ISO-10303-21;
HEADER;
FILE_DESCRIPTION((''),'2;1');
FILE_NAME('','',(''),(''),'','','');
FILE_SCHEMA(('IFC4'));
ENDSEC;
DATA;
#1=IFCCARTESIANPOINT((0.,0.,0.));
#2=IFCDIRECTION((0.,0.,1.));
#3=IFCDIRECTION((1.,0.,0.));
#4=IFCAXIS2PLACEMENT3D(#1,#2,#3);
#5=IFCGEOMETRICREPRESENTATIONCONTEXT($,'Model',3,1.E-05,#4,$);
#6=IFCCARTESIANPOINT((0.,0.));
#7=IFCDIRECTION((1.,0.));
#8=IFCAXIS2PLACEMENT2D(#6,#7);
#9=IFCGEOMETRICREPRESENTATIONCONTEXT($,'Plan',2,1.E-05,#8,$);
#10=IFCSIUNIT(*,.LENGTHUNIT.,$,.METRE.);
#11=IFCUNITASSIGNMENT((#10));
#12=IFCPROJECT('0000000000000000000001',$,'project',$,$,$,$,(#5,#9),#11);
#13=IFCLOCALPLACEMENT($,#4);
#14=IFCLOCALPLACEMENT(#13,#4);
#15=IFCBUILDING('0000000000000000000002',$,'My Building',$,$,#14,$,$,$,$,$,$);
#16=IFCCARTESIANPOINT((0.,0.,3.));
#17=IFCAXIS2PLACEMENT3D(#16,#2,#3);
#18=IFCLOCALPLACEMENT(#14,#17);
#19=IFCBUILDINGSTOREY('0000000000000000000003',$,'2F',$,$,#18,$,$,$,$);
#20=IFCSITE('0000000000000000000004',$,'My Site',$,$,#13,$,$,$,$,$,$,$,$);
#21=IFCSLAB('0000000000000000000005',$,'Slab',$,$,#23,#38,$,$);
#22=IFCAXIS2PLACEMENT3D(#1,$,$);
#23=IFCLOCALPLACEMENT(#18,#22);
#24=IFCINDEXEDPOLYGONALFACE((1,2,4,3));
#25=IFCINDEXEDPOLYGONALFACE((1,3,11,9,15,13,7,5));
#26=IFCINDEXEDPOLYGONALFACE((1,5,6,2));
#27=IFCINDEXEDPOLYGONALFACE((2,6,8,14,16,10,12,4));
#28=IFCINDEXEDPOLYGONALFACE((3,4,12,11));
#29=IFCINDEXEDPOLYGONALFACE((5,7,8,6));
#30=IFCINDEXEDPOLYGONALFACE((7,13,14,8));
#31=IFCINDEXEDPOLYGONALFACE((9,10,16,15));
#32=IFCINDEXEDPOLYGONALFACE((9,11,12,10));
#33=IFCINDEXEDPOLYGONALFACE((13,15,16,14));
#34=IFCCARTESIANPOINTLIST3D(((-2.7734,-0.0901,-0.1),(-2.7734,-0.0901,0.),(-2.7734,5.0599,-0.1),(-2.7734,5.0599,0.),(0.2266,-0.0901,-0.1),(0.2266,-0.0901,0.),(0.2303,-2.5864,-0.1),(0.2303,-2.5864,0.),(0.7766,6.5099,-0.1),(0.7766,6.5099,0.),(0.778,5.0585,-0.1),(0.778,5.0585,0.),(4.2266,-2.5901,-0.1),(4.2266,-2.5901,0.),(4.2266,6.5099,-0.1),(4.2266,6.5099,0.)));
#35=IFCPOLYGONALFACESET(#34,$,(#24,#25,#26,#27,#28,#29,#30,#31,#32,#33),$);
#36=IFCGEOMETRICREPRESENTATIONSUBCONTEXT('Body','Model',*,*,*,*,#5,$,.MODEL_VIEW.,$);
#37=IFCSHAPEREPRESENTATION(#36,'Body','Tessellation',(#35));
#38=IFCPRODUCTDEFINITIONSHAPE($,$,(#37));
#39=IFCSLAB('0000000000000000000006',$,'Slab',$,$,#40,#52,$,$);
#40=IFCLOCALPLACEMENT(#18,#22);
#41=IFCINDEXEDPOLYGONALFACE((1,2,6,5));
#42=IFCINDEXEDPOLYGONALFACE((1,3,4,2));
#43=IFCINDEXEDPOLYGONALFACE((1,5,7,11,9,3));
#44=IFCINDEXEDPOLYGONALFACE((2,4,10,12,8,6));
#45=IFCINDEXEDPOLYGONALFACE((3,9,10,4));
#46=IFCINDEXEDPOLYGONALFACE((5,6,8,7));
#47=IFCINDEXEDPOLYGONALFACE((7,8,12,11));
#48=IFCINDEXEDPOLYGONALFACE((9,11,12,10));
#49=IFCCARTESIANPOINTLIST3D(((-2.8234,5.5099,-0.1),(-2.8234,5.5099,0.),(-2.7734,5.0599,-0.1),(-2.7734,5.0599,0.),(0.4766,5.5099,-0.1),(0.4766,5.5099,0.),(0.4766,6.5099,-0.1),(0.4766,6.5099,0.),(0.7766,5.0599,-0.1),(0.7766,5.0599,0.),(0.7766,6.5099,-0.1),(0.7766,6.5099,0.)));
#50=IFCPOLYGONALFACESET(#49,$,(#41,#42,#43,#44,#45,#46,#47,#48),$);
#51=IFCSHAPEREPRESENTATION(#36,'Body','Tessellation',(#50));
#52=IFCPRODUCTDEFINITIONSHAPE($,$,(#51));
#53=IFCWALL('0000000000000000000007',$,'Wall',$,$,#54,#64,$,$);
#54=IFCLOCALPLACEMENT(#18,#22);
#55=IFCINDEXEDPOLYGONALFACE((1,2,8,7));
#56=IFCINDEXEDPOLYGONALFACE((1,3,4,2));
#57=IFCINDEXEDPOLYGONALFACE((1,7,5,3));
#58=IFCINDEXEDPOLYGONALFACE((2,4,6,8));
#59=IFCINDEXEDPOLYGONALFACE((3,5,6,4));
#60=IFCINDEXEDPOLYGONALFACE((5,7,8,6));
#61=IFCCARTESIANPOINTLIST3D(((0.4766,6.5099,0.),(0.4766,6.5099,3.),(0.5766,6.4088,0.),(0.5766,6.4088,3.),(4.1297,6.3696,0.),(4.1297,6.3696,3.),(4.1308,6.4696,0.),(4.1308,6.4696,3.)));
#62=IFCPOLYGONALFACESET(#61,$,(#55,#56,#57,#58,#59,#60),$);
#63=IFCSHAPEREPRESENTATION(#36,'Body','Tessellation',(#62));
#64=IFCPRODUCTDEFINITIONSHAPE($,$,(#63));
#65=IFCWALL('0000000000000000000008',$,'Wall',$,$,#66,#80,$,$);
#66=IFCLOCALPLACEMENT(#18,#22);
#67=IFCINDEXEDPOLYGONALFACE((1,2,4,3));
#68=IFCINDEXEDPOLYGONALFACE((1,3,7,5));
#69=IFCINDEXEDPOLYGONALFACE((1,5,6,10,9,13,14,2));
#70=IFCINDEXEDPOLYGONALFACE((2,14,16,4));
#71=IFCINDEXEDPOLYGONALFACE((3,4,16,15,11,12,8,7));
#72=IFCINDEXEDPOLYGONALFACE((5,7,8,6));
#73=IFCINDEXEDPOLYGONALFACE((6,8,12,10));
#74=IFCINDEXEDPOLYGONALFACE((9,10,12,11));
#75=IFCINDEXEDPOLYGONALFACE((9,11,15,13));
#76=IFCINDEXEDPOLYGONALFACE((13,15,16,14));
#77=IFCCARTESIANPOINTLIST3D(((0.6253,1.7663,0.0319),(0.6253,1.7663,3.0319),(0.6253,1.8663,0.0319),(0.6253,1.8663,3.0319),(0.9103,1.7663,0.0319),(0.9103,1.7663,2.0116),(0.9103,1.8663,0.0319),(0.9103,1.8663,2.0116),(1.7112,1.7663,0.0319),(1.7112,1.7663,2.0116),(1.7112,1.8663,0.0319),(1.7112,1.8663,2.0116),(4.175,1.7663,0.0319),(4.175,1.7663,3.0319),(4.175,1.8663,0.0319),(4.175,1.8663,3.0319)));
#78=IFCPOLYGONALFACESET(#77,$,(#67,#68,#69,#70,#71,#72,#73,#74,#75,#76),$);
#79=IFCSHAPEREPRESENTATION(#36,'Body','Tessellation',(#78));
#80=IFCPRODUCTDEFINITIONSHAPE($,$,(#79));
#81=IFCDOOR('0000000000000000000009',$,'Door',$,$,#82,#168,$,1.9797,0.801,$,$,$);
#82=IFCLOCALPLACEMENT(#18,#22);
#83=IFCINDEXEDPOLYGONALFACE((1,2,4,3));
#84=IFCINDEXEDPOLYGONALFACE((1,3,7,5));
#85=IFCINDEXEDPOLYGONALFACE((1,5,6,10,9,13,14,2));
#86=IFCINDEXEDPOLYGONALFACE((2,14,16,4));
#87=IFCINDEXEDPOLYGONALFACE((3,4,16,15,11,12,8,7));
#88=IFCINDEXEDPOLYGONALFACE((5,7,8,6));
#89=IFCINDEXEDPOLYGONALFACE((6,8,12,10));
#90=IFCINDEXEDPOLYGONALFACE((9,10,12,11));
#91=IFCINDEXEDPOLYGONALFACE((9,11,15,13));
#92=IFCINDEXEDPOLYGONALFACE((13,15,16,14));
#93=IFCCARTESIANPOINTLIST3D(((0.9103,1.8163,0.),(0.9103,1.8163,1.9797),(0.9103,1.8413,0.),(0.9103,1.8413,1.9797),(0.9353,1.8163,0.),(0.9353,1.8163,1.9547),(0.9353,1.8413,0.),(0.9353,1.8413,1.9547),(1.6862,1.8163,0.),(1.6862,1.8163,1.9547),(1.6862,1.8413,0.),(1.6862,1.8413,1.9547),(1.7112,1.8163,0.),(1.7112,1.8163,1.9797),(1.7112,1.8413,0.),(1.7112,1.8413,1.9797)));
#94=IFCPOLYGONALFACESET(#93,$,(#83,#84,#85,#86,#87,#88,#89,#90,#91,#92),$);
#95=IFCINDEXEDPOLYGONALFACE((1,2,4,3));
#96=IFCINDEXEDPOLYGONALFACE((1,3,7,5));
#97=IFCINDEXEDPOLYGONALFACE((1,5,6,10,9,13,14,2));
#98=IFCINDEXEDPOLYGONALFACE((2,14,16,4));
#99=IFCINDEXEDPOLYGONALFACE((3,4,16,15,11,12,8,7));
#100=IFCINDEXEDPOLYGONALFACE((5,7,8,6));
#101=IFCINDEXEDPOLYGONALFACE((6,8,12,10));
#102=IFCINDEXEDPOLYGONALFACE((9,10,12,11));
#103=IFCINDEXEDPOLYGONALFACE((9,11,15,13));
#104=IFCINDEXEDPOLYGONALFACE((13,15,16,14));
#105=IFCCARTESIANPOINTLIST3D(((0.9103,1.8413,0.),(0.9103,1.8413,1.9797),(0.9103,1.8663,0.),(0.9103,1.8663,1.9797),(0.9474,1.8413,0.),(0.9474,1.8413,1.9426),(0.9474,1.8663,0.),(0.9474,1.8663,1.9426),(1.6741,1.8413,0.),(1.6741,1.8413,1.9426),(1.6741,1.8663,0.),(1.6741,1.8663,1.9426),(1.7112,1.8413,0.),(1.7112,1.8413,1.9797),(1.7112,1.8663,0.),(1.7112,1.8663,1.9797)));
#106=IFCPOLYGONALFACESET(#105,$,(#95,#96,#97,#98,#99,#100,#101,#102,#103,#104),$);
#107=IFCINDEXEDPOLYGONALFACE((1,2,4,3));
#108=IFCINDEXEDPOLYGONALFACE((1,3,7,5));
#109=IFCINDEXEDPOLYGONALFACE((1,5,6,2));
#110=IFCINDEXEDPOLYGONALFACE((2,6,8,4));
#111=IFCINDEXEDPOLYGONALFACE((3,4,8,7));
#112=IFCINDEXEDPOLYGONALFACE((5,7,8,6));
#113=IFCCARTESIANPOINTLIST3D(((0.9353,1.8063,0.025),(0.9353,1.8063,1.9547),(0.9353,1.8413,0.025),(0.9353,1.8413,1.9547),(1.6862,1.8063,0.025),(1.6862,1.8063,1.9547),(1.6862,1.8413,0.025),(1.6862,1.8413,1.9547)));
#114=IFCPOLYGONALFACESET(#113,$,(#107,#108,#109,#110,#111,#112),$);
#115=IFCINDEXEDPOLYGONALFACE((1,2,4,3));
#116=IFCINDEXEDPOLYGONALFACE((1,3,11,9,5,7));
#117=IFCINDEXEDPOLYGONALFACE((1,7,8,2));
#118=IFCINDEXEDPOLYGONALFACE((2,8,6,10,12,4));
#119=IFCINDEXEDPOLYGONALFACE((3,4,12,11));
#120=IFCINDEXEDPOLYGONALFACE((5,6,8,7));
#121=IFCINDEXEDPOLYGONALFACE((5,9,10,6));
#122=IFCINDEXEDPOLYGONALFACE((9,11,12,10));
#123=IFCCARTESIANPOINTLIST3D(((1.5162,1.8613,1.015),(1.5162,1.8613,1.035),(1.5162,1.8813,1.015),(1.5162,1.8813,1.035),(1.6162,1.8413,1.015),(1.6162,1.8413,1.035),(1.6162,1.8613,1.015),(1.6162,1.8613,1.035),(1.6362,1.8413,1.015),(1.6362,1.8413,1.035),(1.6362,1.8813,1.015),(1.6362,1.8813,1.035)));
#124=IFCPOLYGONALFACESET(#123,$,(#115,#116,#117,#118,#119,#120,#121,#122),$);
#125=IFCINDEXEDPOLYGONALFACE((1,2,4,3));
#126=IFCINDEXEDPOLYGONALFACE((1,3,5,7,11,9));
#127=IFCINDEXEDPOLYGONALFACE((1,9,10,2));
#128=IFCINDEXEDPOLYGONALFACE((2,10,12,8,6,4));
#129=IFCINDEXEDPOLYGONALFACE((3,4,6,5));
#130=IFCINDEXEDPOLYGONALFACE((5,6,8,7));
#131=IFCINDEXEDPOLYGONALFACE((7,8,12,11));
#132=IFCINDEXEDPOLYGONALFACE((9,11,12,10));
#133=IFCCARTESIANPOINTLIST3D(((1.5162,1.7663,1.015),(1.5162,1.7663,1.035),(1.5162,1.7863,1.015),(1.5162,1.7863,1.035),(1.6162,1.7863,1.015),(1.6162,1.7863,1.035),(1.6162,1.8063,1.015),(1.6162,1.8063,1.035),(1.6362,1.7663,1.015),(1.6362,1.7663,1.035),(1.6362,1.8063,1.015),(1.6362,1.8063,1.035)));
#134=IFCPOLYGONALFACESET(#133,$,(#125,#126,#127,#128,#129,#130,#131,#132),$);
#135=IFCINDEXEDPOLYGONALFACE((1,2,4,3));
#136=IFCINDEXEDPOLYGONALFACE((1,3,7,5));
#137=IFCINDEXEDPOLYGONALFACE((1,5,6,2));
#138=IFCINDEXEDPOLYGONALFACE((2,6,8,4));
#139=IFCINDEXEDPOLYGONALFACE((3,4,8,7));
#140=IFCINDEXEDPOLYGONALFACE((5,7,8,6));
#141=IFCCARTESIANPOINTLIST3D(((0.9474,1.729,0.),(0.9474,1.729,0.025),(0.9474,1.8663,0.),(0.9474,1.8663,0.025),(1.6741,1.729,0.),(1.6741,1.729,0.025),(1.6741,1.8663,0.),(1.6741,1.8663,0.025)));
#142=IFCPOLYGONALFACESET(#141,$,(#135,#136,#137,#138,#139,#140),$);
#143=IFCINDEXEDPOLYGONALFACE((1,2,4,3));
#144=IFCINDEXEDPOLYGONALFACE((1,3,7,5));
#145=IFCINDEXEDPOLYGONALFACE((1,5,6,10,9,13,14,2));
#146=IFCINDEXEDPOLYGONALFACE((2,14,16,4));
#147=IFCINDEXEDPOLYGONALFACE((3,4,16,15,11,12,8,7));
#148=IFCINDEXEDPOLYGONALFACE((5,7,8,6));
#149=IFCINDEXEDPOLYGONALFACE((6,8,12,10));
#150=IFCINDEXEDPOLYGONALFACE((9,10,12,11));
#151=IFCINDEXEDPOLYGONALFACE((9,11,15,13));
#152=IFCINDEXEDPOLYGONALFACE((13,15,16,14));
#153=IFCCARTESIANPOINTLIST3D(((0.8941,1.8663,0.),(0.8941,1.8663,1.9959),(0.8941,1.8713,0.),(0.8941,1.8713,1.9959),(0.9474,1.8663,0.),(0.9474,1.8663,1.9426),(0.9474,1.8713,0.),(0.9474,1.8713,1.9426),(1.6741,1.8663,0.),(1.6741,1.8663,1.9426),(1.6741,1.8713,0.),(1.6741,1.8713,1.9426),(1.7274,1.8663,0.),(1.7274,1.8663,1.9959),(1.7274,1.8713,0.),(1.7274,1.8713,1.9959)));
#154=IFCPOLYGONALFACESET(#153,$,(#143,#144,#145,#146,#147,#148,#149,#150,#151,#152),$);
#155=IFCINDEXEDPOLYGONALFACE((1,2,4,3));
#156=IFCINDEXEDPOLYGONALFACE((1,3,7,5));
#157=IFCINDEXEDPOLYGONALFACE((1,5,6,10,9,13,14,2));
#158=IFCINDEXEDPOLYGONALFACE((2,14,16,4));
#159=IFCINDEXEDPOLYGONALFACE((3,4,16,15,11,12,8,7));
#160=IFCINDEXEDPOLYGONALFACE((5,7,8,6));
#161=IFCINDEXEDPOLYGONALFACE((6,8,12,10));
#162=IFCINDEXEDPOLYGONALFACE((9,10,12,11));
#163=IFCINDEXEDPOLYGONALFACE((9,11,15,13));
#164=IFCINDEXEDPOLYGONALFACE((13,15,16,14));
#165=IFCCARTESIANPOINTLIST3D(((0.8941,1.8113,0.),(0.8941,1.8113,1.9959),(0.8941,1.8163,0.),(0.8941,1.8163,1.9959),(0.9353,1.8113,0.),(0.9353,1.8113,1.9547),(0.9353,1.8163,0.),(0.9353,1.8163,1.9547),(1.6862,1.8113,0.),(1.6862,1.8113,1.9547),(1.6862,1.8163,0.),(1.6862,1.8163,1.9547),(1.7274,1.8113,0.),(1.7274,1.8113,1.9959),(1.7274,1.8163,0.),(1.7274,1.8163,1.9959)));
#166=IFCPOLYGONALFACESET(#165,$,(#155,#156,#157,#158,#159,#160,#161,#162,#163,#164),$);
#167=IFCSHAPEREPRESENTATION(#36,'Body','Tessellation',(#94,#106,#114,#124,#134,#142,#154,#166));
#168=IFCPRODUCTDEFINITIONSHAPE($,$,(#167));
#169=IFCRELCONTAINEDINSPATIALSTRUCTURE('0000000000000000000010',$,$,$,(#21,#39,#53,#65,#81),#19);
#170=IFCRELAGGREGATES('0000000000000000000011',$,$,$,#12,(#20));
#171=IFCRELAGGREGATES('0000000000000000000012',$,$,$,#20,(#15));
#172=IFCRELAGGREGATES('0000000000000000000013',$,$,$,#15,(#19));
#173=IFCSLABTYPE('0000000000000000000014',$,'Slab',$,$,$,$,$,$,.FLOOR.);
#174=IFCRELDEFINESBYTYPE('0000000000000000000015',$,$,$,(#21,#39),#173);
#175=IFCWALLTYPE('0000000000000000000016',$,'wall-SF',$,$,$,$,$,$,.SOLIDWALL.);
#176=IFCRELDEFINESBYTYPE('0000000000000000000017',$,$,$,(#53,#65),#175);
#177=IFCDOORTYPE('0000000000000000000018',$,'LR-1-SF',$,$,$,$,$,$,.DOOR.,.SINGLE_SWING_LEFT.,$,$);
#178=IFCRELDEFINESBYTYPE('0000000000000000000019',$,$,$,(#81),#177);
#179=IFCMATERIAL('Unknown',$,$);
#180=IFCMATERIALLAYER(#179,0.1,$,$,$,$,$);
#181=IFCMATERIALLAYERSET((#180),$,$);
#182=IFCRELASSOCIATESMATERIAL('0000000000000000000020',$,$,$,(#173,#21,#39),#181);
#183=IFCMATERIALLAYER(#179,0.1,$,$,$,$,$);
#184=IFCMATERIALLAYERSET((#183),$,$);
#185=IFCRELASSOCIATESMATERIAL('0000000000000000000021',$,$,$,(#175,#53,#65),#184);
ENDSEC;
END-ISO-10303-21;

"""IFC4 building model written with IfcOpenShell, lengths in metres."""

from ifc_helpers import new_model, entity, si_unit, frame, origin_with_axes, origin_2d_with_axis, place, context, subcontext, project, spatial, line, indexed_curve, outline, extrude, shape, source, transform, mapped, material, layer, layer_set, layer_usage, type_object, type_shapes, element, fill, save


model = new_model("IFC4")

# Units and contexts
model_context = context("Model", 3, precision=1e-05, world=origin_with_axes())
plan_context = context("Plan", 2, precision=1e-05, world=origin_2d_with_axis())
body_context_1 = subcontext(model_context, "Body", "Model", "MODEL_VIEW")
body_context_2 = subcontext(plan_context, "Body", "Plan", "PLAN_VIEW")
ifc_project = project(units=[si_unit("LENGTHUNIT", "METRE")], contexts=[model_context, plan_context])

# Site, building, storey
site_placement = place(None, origin_with_axes())
site = spatial("IfcSite", under=ifc_project, at=site_placement, Name="My Site")
building_placement = place(site_placement, origin_with_axes())
building = spatial("IfcBuilding", under=site, at=building_placement, Name="My Building")
storey_placement = place(building_placement, frame((0.0, 0.0, 3.0), z_axis=(0.0, 0.0, 1.0), x_axis=(1.0, 0.0, 0.0)))
storey = spatial("IfcBuildingStorey", under=building, at=storey_placement, Name="2F")

# Slabs
ifc_material = material(Name="Unknown")
ifc_layer_1 = layer(ifc_material, 0.1)
ifc_layer_set_1 = layer_set([ifc_layer_1])
ifc_layer_usage_1 = layer_usage(ifc_layer_set_1, "AXIS3", "POSITIVE", -0.1)
slab_type = type_object("IfcSlabType", Name="Slab", PredefinedType="FLOOR", material=ifc_layer_set_1)
slab_1_placement = place(storey_placement, frame((0.7766, 6.5099, 0.0), z_axis=(0.0, 0.0, 1.0), x_axis=(1.0, 0.0, 0.0)))
element("IfcSlab", 1, at=slab_1_placement, inside=storey, type_object=slab_type, material=ifc_layer_usage_1, Name="Slab", context=body_context_1, shape_type="SweptSolid", body=[
    extrude(outline(indexed_curve([(0.0, 0.0), (3.45, 0.0), (3.45, -9.1), (-0.5463, -9.0963), (-0.55, -6.6), (-3.55, -6.6), (-3.55, -1.45), (0.0014, -1.4514), (0.0, 0.0)])), frame((0.0, 0.0, -0.1), z_axis=(0.0, 0.0, 1.0), x_axis=(1.0, 0.0, 0.0)), (0.0, 0.0, 1.0), 0.1),
])
ifc_layer_usage_2 = layer_usage(ifc_layer_set_1, "AXIS3", "POSITIVE", -0.1)
slab_2_placement = place(storey_placement, frame((0.7766, 6.5099, 0.0), z_axis=(0.0, 0.0, 1.0), x_axis=(1.0, 0.0, 0.0)))
element("IfcSlab", 2, at=slab_2_placement, inside=storey, type_object=slab_type, material=ifc_layer_usage_2, Name="Slab", context=body_context_1, shape_type="SweptSolid", body=[
    extrude(outline(indexed_curve([(0.0, 0.0), (-0.3, 0.0), (-0.3, -1.0), (-3.6, -1.0), (-3.55, -1.45), (0.0, -1.45), (0.0, 0.0)])), frame((0.0, 0.0, -0.1), z_axis=(0.0, 0.0, 1.0), x_axis=(1.0, 0.0, 0.0)), (0.0, 0.0, 1.0), 0.1),
])

# Wall
ifc_layer_2 = layer(ifc_material, 0.1)
ifc_layer_set_2 = layer_set([ifc_layer_2])
ifc_layer_usage_3 = layer_usage(ifc_layer_set_2, "AXIS2", "POSITIVE", 0.0)
wall_type = type_object("IfcWallType", Name="wall-SF", PredefinedType="SOLIDWALL", material=ifc_layer_set_2)
wall_1_placement = place(storey_placement, frame((4.1308, 6.4696, 0.0), z_axis=(0.0, 0.0, 1.0), x_axis=(-0.999939, 0.011034, 0.0)))
element("IfcWall", 3, at=wall_1_placement, inside=storey, type_object=wall_type, material=ifc_layer_usage_3, Name="Wall", context=body_context_1, shape_type="SweptSolid", body=[
    extrude(outline(indexed_curve([(0.0, 0.0), (0.0, 0.1), (3.5533, 0.1), (3.6544, 0.0)], segments=[line(1, 2, 3, 4, 1)])), origin_with_axes(), (0.0, 0.0, 1.0), 3.0),
])

# Wall, opening, door
ifc_layer_usage_4 = layer_usage(ifc_layer_set_2, "AXIS2", "POSITIVE", 0.0)
wall_2_placement = place(storey_placement, frame((0.6253, 1.7663, 0.0319), z_axis=(0.0, 0.0, 1.0), x_axis=(1.0, 0.0, 0.0)))
wall_2 = element("IfcWall", 4, at=wall_2_placement, inside=storey, type_object=wall_type, material=ifc_layer_usage_4, Name="Wall", context=body_context_1, shape_type="SweptSolid", body=[
    extrude(outline(indexed_curve([(0.0, 0.0), (0.0, 0.1), (3.5497, 0.1), (3.5497, 0.0)], segments=[line(1, 2, 3, 4, 1)])), origin_with_axes(), (0.0, 0.0, 1.0), 3.0),
])
shared_shape_1 = source(origin_with_axes(), body_context_1, "Body", "SweptSolid", [
    extrude(outline(indexed_curve([(0.0, 0.0), (0.801, 0.0), (0.801, 1.9797), (0.0, 1.9797)], segments=[line(1, 2, 3, 4, 1)])), frame((0.0, -0.6, 0.0), z_axis=(0.0, -1.0, 0.0), x_axis=(1.0, 0.0, 0.0)), (0.0, 0.0, -1.0), 1.2),
])
opening_1_placement = place(wall_2_placement, frame((1.0859, 0.1, 0.0), z_axis=(0.0, 0.0, 1.0), x_axis=(-1.0, 0.0, 0.0)))
opening_1 = element("IfcOpeningElement", 5, at=opening_1_placement, cuts=wall_2, PredefinedType="OPENING", context=body_context_1, shape_type="MappedRepresentation", body=[
    mapped(shared_shape_1, transform((0.0, 0.0, 0.0), x_axis=(1.0, 0.0, 0.0), y_axis=(0.0, 1.0, 0.0), z_axis=(0.0, 0.0, 1.0), scale=1.0)),
])
door_type_1 = type_object("IfcDoorType", Name="LR-1-SF", OperationType="SINGLE_SWING_LEFT", PredefinedType="DOOR")
shared_shape_2 = source(origin_with_axes(), body_context_1, "Body", "SweptSolid", [
    extrude(outline(indexed_curve([(0.0, 0.0), (0.0, 1.9797), (0.801, 1.9797), (0.801, 0.0), (0.776, 0.0), (0.776, 1.9547), (0.025, 1.9547), (0.025, 0.0)], segments=[line(1, 2, 3, 4, 5, 6, 7, 8, 1)])), frame((0.0, 0.025, 0.0), z_axis=(0.0, -1.0, 0.0), x_axis=(1.0, 0.0, 0.0)), (0.0, 0.0, -1.0), 0.025),
    extrude(outline(indexed_curve([(0.0, 0.0), (0.0, 1.9797), (0.801, 1.9797), (0.801, 0.0), (0.7639, 0.0), (0.7639, 1.9426), (0.0371, 1.9426), (0.0371, 0.0)], segments=[line(1, 2, 3, 4, 5, 6, 7, 8, 1)])), frame((0.0, 0.0, 0.0), z_axis=(0.0, -1.0, 0.0), x_axis=(1.0, 0.0, 0.0)), (0.0, 0.0, -1.0), 0.025),
    extrude(outline(indexed_curve([(0.0, 0.0), (0.751, 0.0), (0.751, 0.035), (0.0, 0.035)], segments=[line(1, 2, 3, 4, 1)])), frame((0.025, 0.025, 0.025), z_axis=(0.0, 0.0, 1.0), x_axis=(1.0, 0.0, 0.0)), (0.0, 0.0, 1.0), 1.9297),
    extrude(outline(indexed_curve([(0.0, 0.0), (0.0, -0.04), (0.12, -0.04), (0.12, -0.02), (0.02, -0.02), (0.02, 0.0)], segments=[line(1, 2, 3, 4, 5, 6, 1)])), frame((0.075, 0.025, 1.015), z_axis=(0.0, 0.0, 1.0), x_axis=(1.0, 0.0, 0.0)), (0.0, 0.0, 1.0), 0.02),
    extrude(outline(indexed_curve([(0.0, 0.0), (0.0, 0.04), (0.12, 0.04), (0.12, 0.02), (0.02, 0.02), (0.02, 0.0)], segments=[line(1, 2, 3, 4, 5, 6, 1)])), frame((0.075, 0.06, 1.015), z_axis=(0.0, 0.0, 1.0), x_axis=(1.0, 0.0, 0.0)), (0.0, 0.0, 1.0), 0.02),
    extrude(outline(indexed_curve([(0.0, 0.0), (0.7268, 0.0), (0.7268, 0.1372), (0.0, 0.1372)], segments=[line(1, 2, 3, 4, 1)])), frame((0.0371, 0.0, 0.0), z_axis=(0.0, 0.0, 1.0), x_axis=(1.0, 0.0, 0.0)), (0.0, 0.0, 1.0), 0.025),
    extrude(outline(indexed_curve([(0.0, 0.0), (0.0, 1.9959), (0.8333, 1.9959), (0.8333, 0.0), (0.78, 0.0), (0.78, 1.9426), (0.0532, 1.9426), (0.0532, 0.0)], segments=[line(1, 2, 3, 4, 5, 6, 7, 8, 1)])), frame((-0.0162, -0.005, 0.0), z_axis=(0.0, -1.0, 0.0), x_axis=(1.0, 0.0, 0.0)), (0.0, 0.0, -1.0), 0.005),
    extrude(outline(indexed_curve([(0.0, 0.0), (0.0, 1.9959), (0.8333, 1.9959), (0.8333, 0.0), (0.7921, 0.0), (0.7921, 1.9547), (0.0412, 1.9547), (0.0412, 0.0)], segments=[line(1, 2, 3, 4, 5, 6, 7, 8, 1)])), frame((-0.0162, 0.05, 0.0), z_axis=(0.0, -1.0, 0.0), x_axis=(1.0, 0.0, 0.0)), (0.0, 0.0, -1.0), 0.005),
])
shared_shape_3 = source(origin_with_axes(), body_context_2, "Body", "Curve2D", [
    entity("IfcIndexedPolyCurve", entity("IfcCartesianPointList2D", [[0.0, 0.0], [0.0, 0.05], [0.025, 0.05], [0.025, 0.025], [0.0371, 0.025], [0.0371, 0.0]]), [entity("IfcLineIndex", [1, 2, 3, 4, 5, 6, 1])]),
    entity("IfcIndexedPolyCurve", entity("IfcCartesianPointList2D", [[0.801, 0.0], [0.801, 0.05], [0.776, 0.05], [0.776, 0.025], [0.7639, 0.025], [0.7639, 0.0]]), [entity("IfcLineIndex", [1, 2, 3, 4, 5, 6, 1])]),
    entity("IfcTrimmedCurve", entity("IfcEllipse", entity("IfcAxis2Placement2D", entity("IfcCartesianPoint", [0.741, 0.05]), entity("IfcDirection", [1.0, 0.0])), 0.716, 0.751), [entity("IfcCartesianPoint", [0.741, 0.801])], [entity("IfcCartesianPoint", [0.025, 0.05])], True, "CARTESIAN"),
    entity("IfcIndexedPolyCurve", entity("IfcCartesianPointList2D", [[0.776, 0.05], [0.741, 0.05], [0.741, 0.801], [0.776, 0.801]]), [entity("IfcLineIndex", [1, 2, 3, 4, 1])]),
])
type_shapes(door_type_1, [shared_shape_2, shared_shape_3])
door_1_placement = place(opening_1_placement, frame((0.0, 0.0, -0.0319), z_axis=(0.0, 0.0, 1.0), x_axis=(1.0, 0.0, 0.0)))
door_1 = element("IfcDoor", 6, at=door_1_placement, inside=storey, type_object=door_type_1, Name="Door", OverallHeight=1.9797, OverallWidth=0.801, shapes=[
    shape(body_context_1, "Body", "MappedRepresentation", [mapped(shared_shape_2, transform((0.0, 0.0, 0.0), x_axis=(1.0, 0.0, 0.0), y_axis=(0.0, 1.0, 0.0), z_axis=(0.0, 0.0, 1.0), scale=1.0))]),
    shape(body_context_2, "Body", "MappedRepresentation", [mapped(shared_shape_3, transform((0.0, 0.0, 0.0), x_axis=(1.0, 0.0, 0.0), y_axis=(0.0, 1.0, 0.0), z_axis=(0.0, 0.0, 1.0), scale=1.0))]),
])
fill(opening_1, door_1)

save(model, "model.ifc")
